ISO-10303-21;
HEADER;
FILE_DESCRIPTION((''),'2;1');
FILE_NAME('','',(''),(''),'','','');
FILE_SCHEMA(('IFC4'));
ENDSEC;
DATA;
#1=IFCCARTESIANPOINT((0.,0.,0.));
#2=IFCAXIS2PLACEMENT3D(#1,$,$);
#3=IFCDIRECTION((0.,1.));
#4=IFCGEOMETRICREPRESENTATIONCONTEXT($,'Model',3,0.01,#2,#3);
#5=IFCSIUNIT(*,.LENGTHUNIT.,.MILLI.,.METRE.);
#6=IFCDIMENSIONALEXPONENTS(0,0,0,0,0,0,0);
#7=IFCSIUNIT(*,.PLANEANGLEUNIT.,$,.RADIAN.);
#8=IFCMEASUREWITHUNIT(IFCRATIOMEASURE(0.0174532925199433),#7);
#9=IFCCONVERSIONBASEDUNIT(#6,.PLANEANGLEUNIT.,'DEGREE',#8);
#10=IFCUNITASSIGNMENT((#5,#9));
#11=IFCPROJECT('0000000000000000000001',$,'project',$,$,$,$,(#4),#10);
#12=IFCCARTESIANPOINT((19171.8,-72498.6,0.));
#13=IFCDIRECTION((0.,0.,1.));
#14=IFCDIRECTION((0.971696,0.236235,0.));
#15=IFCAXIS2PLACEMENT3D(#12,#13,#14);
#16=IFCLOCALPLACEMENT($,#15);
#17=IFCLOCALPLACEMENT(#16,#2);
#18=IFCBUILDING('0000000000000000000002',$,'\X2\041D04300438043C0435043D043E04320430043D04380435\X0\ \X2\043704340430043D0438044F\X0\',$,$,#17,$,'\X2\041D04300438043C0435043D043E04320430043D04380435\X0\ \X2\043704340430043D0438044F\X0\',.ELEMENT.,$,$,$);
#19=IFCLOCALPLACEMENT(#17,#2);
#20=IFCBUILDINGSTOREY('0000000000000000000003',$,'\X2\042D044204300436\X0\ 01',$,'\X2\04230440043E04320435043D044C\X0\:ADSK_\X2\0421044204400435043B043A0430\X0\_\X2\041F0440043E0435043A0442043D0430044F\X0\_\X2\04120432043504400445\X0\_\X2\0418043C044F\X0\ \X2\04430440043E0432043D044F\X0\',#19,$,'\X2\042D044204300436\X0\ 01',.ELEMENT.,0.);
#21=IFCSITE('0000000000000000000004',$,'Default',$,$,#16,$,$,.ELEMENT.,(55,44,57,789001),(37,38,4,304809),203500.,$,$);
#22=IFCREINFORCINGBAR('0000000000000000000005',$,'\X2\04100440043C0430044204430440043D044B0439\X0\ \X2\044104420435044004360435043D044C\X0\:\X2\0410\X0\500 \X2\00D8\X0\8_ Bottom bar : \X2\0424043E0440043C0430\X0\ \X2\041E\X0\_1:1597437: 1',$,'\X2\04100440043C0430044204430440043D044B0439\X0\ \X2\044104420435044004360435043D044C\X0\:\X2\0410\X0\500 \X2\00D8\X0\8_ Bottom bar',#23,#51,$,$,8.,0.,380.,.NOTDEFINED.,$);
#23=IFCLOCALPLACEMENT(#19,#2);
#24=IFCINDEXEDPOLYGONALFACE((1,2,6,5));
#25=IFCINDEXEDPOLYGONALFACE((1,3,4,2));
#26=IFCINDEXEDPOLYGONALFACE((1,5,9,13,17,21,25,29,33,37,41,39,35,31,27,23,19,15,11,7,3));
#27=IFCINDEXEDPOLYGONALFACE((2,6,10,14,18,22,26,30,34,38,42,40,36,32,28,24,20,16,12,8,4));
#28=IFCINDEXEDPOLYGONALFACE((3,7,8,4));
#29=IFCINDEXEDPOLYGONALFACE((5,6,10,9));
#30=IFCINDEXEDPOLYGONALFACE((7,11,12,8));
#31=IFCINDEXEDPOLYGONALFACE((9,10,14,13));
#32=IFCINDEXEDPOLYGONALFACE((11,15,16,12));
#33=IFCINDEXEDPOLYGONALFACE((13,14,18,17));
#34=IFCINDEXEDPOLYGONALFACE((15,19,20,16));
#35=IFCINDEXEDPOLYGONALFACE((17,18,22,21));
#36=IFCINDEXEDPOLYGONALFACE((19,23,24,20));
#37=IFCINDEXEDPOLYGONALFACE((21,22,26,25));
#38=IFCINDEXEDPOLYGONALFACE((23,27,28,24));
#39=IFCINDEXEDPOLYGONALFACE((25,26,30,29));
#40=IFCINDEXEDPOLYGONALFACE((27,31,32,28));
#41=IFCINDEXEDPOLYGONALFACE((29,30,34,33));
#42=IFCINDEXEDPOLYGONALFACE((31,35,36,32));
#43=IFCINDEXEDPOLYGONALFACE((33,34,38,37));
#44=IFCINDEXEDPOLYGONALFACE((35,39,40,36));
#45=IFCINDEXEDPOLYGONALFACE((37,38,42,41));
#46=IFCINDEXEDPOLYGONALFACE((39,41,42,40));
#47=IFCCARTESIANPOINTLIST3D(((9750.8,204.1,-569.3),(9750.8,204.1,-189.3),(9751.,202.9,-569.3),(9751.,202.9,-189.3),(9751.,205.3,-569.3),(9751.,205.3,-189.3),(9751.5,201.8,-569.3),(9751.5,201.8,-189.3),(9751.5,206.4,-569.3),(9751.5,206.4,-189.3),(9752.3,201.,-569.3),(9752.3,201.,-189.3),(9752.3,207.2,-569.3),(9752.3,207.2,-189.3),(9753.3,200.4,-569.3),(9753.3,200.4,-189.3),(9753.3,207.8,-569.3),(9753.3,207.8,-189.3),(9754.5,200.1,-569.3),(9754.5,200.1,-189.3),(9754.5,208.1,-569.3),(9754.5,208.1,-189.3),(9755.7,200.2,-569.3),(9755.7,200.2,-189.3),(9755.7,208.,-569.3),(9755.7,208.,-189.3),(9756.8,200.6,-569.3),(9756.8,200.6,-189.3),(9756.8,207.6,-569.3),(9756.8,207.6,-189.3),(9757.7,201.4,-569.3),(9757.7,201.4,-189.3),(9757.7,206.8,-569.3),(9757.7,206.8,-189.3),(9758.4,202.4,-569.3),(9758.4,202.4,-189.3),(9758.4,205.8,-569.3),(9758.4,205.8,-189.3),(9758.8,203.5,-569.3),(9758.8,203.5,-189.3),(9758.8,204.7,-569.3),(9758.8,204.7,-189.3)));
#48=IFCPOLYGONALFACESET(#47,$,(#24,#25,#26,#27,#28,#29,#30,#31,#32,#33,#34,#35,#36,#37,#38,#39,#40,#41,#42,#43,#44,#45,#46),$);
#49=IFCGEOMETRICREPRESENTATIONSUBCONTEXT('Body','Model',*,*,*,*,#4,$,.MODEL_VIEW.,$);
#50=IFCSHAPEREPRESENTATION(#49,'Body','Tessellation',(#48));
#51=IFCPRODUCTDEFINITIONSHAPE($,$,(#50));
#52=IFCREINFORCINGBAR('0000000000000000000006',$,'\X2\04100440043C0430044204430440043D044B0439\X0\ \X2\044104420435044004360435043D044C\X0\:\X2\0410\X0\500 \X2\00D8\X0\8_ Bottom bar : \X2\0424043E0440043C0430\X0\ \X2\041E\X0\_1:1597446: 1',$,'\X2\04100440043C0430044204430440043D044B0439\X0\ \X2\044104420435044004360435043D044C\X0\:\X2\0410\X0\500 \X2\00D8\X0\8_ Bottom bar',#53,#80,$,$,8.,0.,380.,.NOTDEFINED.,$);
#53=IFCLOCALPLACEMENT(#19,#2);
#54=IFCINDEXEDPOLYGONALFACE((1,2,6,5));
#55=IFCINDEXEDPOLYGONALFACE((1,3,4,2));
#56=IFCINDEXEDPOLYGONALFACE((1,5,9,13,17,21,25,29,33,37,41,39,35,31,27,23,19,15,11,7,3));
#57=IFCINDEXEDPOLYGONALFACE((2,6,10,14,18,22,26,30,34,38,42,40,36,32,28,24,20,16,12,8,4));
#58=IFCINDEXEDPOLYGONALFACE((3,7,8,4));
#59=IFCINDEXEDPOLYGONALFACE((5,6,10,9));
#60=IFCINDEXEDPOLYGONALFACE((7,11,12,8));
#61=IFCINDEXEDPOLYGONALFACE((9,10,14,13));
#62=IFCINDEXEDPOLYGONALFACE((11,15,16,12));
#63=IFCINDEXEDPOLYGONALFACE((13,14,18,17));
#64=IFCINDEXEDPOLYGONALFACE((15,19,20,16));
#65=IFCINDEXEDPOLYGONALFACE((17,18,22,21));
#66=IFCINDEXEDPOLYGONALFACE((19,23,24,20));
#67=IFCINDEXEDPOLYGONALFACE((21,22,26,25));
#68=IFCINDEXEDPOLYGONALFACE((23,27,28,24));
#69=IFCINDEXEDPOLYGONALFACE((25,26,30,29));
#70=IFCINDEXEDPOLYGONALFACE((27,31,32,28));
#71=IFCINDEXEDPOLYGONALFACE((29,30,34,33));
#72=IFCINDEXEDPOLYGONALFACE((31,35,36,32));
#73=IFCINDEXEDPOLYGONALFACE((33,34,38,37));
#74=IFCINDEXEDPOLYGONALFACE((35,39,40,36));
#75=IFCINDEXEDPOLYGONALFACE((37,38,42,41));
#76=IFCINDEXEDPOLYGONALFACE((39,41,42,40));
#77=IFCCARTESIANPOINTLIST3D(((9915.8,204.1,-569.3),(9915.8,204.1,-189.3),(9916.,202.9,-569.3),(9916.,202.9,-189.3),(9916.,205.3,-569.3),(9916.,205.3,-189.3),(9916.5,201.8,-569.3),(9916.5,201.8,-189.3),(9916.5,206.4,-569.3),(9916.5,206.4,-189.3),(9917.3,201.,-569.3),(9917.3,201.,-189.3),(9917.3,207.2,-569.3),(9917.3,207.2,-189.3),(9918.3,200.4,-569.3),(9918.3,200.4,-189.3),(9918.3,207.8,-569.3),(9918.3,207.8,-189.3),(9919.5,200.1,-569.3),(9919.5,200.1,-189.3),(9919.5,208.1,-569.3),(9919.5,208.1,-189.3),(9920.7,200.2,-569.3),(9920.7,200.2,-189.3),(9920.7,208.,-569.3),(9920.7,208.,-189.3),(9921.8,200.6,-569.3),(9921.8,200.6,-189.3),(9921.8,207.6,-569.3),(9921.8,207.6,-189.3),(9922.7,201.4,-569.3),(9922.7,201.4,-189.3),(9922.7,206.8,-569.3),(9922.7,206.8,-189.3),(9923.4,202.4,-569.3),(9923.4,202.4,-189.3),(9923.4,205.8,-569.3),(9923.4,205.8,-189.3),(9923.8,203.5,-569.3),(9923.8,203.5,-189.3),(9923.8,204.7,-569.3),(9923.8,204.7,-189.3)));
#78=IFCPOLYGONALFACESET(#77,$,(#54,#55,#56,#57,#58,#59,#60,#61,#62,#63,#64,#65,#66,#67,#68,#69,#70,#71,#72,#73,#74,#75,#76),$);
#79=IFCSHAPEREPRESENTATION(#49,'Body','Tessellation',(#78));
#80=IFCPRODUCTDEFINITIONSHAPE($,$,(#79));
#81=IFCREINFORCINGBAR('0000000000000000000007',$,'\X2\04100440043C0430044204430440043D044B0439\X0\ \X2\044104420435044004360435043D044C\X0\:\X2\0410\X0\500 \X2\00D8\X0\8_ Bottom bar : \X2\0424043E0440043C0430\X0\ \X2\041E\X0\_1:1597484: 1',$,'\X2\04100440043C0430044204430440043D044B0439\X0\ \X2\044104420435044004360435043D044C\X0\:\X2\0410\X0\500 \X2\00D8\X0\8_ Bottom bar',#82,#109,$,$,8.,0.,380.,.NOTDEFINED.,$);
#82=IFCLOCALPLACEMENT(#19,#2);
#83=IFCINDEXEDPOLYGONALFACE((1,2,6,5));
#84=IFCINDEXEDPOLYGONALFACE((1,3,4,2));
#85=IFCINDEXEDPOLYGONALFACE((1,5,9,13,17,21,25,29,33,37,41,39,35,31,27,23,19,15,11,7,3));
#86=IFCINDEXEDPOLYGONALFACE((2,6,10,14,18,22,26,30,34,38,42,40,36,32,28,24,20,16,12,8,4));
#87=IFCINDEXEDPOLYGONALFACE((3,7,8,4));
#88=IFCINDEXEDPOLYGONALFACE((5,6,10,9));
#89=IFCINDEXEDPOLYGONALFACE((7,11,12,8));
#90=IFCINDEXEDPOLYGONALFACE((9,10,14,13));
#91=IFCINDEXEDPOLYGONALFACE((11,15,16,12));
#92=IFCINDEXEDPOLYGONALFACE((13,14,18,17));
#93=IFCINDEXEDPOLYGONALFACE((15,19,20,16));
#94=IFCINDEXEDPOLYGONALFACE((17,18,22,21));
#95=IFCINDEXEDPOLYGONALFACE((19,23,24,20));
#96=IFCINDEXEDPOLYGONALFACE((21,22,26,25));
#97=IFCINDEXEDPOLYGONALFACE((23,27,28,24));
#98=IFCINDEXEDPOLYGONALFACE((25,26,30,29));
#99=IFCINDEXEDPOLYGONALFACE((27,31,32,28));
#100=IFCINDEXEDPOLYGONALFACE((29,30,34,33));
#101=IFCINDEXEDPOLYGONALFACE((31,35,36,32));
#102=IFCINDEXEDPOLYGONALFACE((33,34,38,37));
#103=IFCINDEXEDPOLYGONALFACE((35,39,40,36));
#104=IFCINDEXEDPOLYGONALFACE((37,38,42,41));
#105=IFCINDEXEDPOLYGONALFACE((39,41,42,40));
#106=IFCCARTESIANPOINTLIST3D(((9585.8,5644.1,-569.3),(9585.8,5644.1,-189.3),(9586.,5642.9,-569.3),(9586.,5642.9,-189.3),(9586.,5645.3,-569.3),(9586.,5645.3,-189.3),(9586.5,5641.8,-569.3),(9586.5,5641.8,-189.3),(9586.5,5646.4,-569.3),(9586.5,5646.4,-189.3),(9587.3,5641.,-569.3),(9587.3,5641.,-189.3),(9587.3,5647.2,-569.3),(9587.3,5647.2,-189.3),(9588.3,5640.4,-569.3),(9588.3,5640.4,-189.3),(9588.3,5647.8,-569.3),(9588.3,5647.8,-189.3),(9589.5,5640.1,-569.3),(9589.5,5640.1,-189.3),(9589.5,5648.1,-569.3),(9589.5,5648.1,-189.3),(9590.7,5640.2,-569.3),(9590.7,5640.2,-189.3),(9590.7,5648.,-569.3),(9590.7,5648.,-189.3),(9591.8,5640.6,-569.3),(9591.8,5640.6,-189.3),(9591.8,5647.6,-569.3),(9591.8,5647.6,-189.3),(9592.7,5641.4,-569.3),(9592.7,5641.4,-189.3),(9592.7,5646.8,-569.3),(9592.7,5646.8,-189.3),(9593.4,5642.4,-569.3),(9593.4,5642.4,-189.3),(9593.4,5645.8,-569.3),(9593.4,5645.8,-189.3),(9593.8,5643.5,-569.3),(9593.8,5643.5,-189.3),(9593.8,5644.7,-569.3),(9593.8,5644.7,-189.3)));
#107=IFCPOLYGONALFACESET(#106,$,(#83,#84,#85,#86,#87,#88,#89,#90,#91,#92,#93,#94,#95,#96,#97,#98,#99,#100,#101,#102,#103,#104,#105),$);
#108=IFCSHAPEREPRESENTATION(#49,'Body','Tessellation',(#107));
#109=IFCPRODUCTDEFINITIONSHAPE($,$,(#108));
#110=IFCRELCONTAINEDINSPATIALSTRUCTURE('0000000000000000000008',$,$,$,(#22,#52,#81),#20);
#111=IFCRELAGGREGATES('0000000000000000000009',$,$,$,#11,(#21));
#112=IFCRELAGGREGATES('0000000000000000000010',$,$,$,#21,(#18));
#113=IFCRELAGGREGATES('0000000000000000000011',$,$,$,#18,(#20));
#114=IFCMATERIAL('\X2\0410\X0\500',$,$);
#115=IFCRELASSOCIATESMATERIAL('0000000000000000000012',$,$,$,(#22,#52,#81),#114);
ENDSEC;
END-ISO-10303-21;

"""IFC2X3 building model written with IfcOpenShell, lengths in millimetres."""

from ifc_helpers import new_model, entity, si_unit, converted_unit, direction, frame, origin, place, context, subcontext, project, spatial, material, element, save


model = new_model("IFC2X3")

# Units and contexts
model_context = context("Model", 3, precision=0.01, world=origin(), true_north=direction((0.0, 1.0)))
body_context = subcontext(model_context, "Body", "Model", "MODEL_VIEW")
ifc_project = project(units=[si_unit("LENGTHUNIT", "METRE", prefix="MILLI"), converted_unit("PLANEANGLEUNIT", "DEGREE", entity("IfcRatioMeasure", 0.0174532925199433), si_unit("PLANEANGLEUNIT", "RADIAN"), dimensions=[0, 0, 0, 0, 0, 0, 0])], contexts=[model_context])

# Site, building, storey
site_placement = place(None, frame((19171.8, -72498.6, 0.0), z_axis=(0.0, 0.0, 1.0), x_axis=(0.971696, 0.236235, 0.0)))
site = spatial("IfcSite", under=ifc_project, at=site_placement, Name="Default", CompositionType="ELEMENT", RefLatitude=(55, 44, 57, 789001), RefLongitude=(37, 38, 4, 304809), RefElevation=203500.0)
building_placement = place(site_placement, origin())
building = spatial("IfcBuilding", under=site, at=building_placement, Name="Наименование здания", LongName="Наименование здания", CompositionType="ELEMENT")
storey_placement = place(building_placement, origin())
storey = spatial("IfcBuildingStorey", under=building, at=storey_placement, Name="Этаж 01", ObjectType="Уровень:ADSK_Стрелка_Проектная_Вверх_Имя уровня", LongName="Этаж 01", CompositionType="ELEMENT", Elevation=0.0)

# Reinforcing bars
ifc_material = material(Name="А500")
placement = place(storey_placement, origin())
element("IfcReinforcingBar", 1, at=placement, inside=storey, material=ifc_material, Name="Арматурный стержень:А500 Ø8_ Bottom bar : Форма О_1:1597437: 1", ObjectType="Арматурный стержень:А500 Ø8_ Bottom bar", BarLength=380.0, BarRole="NOTDEFINED", CrossSectionArea=0.0, NominalDiameter=8.0, context=body_context, shape_type="AdvancedSweptSolid", body=[
    entity("IfcSweptDiskSolid", entity("IfcCompositeCurve", [entity("IfcCompositeCurveSegment", "CONTINUOUS", True, entity("IfcPolyline", [entity("IfcCartesianPoint", [9754.8, 204.1, -189.3]), entity("IfcCartesianPoint", [9754.8, 204.1, -569.3])]))], False), 4.0, None, 0.0, 1.0),
])
element("IfcReinforcingBar", 2, at=placement, inside=storey, material=ifc_material, Name="Арматурный стержень:А500 Ø8_ Bottom bar : Форма О_1:1597446: 1", ObjectType="Арматурный стержень:А500 Ø8_ Bottom bar", BarLength=380.0, BarRole="NOTDEFINED", CrossSectionArea=0.0, NominalDiameter=8.0, context=body_context, shape_type="AdvancedSweptSolid", body=[
    entity("IfcSweptDiskSolid", entity("IfcCompositeCurve", [entity("IfcCompositeCurveSegment", "CONTINUOUS", True, entity("IfcPolyline", [entity("IfcCartesianPoint", [9919.8, 204.1, -189.3]), entity("IfcCartesianPoint", [9919.8, 204.1, -569.3])]))], False), 4.0, None, 0.0, 1.0),
])
element("IfcReinforcingBar", 3, at=placement, inside=storey, material=ifc_material, Name="Арматурный стержень:А500 Ø8_ Bottom bar : Форма О_1:1597484: 1", ObjectType="Арматурный стержень:А500 Ø8_ Bottom bar", BarLength=380.0, BarRole="NOTDEFINED", CrossSectionArea=0.0, NominalDiameter=8.0, context=body_context, shape_type="AdvancedSweptSolid", body=[
    entity("IfcSweptDiskSolid", entity("IfcCompositeCurve", [entity("IfcCompositeCurveSegment", "CONTINUOUS", True, entity("IfcPolyline", [entity("IfcCartesianPoint", [9589.8, 5644.1, -189.3]), entity("IfcCartesianPoint", [9589.8, 5644.1, -569.3])]))], False), 4.0, None, 0.0, 1.0),
])

save(model, "model.ifc")
